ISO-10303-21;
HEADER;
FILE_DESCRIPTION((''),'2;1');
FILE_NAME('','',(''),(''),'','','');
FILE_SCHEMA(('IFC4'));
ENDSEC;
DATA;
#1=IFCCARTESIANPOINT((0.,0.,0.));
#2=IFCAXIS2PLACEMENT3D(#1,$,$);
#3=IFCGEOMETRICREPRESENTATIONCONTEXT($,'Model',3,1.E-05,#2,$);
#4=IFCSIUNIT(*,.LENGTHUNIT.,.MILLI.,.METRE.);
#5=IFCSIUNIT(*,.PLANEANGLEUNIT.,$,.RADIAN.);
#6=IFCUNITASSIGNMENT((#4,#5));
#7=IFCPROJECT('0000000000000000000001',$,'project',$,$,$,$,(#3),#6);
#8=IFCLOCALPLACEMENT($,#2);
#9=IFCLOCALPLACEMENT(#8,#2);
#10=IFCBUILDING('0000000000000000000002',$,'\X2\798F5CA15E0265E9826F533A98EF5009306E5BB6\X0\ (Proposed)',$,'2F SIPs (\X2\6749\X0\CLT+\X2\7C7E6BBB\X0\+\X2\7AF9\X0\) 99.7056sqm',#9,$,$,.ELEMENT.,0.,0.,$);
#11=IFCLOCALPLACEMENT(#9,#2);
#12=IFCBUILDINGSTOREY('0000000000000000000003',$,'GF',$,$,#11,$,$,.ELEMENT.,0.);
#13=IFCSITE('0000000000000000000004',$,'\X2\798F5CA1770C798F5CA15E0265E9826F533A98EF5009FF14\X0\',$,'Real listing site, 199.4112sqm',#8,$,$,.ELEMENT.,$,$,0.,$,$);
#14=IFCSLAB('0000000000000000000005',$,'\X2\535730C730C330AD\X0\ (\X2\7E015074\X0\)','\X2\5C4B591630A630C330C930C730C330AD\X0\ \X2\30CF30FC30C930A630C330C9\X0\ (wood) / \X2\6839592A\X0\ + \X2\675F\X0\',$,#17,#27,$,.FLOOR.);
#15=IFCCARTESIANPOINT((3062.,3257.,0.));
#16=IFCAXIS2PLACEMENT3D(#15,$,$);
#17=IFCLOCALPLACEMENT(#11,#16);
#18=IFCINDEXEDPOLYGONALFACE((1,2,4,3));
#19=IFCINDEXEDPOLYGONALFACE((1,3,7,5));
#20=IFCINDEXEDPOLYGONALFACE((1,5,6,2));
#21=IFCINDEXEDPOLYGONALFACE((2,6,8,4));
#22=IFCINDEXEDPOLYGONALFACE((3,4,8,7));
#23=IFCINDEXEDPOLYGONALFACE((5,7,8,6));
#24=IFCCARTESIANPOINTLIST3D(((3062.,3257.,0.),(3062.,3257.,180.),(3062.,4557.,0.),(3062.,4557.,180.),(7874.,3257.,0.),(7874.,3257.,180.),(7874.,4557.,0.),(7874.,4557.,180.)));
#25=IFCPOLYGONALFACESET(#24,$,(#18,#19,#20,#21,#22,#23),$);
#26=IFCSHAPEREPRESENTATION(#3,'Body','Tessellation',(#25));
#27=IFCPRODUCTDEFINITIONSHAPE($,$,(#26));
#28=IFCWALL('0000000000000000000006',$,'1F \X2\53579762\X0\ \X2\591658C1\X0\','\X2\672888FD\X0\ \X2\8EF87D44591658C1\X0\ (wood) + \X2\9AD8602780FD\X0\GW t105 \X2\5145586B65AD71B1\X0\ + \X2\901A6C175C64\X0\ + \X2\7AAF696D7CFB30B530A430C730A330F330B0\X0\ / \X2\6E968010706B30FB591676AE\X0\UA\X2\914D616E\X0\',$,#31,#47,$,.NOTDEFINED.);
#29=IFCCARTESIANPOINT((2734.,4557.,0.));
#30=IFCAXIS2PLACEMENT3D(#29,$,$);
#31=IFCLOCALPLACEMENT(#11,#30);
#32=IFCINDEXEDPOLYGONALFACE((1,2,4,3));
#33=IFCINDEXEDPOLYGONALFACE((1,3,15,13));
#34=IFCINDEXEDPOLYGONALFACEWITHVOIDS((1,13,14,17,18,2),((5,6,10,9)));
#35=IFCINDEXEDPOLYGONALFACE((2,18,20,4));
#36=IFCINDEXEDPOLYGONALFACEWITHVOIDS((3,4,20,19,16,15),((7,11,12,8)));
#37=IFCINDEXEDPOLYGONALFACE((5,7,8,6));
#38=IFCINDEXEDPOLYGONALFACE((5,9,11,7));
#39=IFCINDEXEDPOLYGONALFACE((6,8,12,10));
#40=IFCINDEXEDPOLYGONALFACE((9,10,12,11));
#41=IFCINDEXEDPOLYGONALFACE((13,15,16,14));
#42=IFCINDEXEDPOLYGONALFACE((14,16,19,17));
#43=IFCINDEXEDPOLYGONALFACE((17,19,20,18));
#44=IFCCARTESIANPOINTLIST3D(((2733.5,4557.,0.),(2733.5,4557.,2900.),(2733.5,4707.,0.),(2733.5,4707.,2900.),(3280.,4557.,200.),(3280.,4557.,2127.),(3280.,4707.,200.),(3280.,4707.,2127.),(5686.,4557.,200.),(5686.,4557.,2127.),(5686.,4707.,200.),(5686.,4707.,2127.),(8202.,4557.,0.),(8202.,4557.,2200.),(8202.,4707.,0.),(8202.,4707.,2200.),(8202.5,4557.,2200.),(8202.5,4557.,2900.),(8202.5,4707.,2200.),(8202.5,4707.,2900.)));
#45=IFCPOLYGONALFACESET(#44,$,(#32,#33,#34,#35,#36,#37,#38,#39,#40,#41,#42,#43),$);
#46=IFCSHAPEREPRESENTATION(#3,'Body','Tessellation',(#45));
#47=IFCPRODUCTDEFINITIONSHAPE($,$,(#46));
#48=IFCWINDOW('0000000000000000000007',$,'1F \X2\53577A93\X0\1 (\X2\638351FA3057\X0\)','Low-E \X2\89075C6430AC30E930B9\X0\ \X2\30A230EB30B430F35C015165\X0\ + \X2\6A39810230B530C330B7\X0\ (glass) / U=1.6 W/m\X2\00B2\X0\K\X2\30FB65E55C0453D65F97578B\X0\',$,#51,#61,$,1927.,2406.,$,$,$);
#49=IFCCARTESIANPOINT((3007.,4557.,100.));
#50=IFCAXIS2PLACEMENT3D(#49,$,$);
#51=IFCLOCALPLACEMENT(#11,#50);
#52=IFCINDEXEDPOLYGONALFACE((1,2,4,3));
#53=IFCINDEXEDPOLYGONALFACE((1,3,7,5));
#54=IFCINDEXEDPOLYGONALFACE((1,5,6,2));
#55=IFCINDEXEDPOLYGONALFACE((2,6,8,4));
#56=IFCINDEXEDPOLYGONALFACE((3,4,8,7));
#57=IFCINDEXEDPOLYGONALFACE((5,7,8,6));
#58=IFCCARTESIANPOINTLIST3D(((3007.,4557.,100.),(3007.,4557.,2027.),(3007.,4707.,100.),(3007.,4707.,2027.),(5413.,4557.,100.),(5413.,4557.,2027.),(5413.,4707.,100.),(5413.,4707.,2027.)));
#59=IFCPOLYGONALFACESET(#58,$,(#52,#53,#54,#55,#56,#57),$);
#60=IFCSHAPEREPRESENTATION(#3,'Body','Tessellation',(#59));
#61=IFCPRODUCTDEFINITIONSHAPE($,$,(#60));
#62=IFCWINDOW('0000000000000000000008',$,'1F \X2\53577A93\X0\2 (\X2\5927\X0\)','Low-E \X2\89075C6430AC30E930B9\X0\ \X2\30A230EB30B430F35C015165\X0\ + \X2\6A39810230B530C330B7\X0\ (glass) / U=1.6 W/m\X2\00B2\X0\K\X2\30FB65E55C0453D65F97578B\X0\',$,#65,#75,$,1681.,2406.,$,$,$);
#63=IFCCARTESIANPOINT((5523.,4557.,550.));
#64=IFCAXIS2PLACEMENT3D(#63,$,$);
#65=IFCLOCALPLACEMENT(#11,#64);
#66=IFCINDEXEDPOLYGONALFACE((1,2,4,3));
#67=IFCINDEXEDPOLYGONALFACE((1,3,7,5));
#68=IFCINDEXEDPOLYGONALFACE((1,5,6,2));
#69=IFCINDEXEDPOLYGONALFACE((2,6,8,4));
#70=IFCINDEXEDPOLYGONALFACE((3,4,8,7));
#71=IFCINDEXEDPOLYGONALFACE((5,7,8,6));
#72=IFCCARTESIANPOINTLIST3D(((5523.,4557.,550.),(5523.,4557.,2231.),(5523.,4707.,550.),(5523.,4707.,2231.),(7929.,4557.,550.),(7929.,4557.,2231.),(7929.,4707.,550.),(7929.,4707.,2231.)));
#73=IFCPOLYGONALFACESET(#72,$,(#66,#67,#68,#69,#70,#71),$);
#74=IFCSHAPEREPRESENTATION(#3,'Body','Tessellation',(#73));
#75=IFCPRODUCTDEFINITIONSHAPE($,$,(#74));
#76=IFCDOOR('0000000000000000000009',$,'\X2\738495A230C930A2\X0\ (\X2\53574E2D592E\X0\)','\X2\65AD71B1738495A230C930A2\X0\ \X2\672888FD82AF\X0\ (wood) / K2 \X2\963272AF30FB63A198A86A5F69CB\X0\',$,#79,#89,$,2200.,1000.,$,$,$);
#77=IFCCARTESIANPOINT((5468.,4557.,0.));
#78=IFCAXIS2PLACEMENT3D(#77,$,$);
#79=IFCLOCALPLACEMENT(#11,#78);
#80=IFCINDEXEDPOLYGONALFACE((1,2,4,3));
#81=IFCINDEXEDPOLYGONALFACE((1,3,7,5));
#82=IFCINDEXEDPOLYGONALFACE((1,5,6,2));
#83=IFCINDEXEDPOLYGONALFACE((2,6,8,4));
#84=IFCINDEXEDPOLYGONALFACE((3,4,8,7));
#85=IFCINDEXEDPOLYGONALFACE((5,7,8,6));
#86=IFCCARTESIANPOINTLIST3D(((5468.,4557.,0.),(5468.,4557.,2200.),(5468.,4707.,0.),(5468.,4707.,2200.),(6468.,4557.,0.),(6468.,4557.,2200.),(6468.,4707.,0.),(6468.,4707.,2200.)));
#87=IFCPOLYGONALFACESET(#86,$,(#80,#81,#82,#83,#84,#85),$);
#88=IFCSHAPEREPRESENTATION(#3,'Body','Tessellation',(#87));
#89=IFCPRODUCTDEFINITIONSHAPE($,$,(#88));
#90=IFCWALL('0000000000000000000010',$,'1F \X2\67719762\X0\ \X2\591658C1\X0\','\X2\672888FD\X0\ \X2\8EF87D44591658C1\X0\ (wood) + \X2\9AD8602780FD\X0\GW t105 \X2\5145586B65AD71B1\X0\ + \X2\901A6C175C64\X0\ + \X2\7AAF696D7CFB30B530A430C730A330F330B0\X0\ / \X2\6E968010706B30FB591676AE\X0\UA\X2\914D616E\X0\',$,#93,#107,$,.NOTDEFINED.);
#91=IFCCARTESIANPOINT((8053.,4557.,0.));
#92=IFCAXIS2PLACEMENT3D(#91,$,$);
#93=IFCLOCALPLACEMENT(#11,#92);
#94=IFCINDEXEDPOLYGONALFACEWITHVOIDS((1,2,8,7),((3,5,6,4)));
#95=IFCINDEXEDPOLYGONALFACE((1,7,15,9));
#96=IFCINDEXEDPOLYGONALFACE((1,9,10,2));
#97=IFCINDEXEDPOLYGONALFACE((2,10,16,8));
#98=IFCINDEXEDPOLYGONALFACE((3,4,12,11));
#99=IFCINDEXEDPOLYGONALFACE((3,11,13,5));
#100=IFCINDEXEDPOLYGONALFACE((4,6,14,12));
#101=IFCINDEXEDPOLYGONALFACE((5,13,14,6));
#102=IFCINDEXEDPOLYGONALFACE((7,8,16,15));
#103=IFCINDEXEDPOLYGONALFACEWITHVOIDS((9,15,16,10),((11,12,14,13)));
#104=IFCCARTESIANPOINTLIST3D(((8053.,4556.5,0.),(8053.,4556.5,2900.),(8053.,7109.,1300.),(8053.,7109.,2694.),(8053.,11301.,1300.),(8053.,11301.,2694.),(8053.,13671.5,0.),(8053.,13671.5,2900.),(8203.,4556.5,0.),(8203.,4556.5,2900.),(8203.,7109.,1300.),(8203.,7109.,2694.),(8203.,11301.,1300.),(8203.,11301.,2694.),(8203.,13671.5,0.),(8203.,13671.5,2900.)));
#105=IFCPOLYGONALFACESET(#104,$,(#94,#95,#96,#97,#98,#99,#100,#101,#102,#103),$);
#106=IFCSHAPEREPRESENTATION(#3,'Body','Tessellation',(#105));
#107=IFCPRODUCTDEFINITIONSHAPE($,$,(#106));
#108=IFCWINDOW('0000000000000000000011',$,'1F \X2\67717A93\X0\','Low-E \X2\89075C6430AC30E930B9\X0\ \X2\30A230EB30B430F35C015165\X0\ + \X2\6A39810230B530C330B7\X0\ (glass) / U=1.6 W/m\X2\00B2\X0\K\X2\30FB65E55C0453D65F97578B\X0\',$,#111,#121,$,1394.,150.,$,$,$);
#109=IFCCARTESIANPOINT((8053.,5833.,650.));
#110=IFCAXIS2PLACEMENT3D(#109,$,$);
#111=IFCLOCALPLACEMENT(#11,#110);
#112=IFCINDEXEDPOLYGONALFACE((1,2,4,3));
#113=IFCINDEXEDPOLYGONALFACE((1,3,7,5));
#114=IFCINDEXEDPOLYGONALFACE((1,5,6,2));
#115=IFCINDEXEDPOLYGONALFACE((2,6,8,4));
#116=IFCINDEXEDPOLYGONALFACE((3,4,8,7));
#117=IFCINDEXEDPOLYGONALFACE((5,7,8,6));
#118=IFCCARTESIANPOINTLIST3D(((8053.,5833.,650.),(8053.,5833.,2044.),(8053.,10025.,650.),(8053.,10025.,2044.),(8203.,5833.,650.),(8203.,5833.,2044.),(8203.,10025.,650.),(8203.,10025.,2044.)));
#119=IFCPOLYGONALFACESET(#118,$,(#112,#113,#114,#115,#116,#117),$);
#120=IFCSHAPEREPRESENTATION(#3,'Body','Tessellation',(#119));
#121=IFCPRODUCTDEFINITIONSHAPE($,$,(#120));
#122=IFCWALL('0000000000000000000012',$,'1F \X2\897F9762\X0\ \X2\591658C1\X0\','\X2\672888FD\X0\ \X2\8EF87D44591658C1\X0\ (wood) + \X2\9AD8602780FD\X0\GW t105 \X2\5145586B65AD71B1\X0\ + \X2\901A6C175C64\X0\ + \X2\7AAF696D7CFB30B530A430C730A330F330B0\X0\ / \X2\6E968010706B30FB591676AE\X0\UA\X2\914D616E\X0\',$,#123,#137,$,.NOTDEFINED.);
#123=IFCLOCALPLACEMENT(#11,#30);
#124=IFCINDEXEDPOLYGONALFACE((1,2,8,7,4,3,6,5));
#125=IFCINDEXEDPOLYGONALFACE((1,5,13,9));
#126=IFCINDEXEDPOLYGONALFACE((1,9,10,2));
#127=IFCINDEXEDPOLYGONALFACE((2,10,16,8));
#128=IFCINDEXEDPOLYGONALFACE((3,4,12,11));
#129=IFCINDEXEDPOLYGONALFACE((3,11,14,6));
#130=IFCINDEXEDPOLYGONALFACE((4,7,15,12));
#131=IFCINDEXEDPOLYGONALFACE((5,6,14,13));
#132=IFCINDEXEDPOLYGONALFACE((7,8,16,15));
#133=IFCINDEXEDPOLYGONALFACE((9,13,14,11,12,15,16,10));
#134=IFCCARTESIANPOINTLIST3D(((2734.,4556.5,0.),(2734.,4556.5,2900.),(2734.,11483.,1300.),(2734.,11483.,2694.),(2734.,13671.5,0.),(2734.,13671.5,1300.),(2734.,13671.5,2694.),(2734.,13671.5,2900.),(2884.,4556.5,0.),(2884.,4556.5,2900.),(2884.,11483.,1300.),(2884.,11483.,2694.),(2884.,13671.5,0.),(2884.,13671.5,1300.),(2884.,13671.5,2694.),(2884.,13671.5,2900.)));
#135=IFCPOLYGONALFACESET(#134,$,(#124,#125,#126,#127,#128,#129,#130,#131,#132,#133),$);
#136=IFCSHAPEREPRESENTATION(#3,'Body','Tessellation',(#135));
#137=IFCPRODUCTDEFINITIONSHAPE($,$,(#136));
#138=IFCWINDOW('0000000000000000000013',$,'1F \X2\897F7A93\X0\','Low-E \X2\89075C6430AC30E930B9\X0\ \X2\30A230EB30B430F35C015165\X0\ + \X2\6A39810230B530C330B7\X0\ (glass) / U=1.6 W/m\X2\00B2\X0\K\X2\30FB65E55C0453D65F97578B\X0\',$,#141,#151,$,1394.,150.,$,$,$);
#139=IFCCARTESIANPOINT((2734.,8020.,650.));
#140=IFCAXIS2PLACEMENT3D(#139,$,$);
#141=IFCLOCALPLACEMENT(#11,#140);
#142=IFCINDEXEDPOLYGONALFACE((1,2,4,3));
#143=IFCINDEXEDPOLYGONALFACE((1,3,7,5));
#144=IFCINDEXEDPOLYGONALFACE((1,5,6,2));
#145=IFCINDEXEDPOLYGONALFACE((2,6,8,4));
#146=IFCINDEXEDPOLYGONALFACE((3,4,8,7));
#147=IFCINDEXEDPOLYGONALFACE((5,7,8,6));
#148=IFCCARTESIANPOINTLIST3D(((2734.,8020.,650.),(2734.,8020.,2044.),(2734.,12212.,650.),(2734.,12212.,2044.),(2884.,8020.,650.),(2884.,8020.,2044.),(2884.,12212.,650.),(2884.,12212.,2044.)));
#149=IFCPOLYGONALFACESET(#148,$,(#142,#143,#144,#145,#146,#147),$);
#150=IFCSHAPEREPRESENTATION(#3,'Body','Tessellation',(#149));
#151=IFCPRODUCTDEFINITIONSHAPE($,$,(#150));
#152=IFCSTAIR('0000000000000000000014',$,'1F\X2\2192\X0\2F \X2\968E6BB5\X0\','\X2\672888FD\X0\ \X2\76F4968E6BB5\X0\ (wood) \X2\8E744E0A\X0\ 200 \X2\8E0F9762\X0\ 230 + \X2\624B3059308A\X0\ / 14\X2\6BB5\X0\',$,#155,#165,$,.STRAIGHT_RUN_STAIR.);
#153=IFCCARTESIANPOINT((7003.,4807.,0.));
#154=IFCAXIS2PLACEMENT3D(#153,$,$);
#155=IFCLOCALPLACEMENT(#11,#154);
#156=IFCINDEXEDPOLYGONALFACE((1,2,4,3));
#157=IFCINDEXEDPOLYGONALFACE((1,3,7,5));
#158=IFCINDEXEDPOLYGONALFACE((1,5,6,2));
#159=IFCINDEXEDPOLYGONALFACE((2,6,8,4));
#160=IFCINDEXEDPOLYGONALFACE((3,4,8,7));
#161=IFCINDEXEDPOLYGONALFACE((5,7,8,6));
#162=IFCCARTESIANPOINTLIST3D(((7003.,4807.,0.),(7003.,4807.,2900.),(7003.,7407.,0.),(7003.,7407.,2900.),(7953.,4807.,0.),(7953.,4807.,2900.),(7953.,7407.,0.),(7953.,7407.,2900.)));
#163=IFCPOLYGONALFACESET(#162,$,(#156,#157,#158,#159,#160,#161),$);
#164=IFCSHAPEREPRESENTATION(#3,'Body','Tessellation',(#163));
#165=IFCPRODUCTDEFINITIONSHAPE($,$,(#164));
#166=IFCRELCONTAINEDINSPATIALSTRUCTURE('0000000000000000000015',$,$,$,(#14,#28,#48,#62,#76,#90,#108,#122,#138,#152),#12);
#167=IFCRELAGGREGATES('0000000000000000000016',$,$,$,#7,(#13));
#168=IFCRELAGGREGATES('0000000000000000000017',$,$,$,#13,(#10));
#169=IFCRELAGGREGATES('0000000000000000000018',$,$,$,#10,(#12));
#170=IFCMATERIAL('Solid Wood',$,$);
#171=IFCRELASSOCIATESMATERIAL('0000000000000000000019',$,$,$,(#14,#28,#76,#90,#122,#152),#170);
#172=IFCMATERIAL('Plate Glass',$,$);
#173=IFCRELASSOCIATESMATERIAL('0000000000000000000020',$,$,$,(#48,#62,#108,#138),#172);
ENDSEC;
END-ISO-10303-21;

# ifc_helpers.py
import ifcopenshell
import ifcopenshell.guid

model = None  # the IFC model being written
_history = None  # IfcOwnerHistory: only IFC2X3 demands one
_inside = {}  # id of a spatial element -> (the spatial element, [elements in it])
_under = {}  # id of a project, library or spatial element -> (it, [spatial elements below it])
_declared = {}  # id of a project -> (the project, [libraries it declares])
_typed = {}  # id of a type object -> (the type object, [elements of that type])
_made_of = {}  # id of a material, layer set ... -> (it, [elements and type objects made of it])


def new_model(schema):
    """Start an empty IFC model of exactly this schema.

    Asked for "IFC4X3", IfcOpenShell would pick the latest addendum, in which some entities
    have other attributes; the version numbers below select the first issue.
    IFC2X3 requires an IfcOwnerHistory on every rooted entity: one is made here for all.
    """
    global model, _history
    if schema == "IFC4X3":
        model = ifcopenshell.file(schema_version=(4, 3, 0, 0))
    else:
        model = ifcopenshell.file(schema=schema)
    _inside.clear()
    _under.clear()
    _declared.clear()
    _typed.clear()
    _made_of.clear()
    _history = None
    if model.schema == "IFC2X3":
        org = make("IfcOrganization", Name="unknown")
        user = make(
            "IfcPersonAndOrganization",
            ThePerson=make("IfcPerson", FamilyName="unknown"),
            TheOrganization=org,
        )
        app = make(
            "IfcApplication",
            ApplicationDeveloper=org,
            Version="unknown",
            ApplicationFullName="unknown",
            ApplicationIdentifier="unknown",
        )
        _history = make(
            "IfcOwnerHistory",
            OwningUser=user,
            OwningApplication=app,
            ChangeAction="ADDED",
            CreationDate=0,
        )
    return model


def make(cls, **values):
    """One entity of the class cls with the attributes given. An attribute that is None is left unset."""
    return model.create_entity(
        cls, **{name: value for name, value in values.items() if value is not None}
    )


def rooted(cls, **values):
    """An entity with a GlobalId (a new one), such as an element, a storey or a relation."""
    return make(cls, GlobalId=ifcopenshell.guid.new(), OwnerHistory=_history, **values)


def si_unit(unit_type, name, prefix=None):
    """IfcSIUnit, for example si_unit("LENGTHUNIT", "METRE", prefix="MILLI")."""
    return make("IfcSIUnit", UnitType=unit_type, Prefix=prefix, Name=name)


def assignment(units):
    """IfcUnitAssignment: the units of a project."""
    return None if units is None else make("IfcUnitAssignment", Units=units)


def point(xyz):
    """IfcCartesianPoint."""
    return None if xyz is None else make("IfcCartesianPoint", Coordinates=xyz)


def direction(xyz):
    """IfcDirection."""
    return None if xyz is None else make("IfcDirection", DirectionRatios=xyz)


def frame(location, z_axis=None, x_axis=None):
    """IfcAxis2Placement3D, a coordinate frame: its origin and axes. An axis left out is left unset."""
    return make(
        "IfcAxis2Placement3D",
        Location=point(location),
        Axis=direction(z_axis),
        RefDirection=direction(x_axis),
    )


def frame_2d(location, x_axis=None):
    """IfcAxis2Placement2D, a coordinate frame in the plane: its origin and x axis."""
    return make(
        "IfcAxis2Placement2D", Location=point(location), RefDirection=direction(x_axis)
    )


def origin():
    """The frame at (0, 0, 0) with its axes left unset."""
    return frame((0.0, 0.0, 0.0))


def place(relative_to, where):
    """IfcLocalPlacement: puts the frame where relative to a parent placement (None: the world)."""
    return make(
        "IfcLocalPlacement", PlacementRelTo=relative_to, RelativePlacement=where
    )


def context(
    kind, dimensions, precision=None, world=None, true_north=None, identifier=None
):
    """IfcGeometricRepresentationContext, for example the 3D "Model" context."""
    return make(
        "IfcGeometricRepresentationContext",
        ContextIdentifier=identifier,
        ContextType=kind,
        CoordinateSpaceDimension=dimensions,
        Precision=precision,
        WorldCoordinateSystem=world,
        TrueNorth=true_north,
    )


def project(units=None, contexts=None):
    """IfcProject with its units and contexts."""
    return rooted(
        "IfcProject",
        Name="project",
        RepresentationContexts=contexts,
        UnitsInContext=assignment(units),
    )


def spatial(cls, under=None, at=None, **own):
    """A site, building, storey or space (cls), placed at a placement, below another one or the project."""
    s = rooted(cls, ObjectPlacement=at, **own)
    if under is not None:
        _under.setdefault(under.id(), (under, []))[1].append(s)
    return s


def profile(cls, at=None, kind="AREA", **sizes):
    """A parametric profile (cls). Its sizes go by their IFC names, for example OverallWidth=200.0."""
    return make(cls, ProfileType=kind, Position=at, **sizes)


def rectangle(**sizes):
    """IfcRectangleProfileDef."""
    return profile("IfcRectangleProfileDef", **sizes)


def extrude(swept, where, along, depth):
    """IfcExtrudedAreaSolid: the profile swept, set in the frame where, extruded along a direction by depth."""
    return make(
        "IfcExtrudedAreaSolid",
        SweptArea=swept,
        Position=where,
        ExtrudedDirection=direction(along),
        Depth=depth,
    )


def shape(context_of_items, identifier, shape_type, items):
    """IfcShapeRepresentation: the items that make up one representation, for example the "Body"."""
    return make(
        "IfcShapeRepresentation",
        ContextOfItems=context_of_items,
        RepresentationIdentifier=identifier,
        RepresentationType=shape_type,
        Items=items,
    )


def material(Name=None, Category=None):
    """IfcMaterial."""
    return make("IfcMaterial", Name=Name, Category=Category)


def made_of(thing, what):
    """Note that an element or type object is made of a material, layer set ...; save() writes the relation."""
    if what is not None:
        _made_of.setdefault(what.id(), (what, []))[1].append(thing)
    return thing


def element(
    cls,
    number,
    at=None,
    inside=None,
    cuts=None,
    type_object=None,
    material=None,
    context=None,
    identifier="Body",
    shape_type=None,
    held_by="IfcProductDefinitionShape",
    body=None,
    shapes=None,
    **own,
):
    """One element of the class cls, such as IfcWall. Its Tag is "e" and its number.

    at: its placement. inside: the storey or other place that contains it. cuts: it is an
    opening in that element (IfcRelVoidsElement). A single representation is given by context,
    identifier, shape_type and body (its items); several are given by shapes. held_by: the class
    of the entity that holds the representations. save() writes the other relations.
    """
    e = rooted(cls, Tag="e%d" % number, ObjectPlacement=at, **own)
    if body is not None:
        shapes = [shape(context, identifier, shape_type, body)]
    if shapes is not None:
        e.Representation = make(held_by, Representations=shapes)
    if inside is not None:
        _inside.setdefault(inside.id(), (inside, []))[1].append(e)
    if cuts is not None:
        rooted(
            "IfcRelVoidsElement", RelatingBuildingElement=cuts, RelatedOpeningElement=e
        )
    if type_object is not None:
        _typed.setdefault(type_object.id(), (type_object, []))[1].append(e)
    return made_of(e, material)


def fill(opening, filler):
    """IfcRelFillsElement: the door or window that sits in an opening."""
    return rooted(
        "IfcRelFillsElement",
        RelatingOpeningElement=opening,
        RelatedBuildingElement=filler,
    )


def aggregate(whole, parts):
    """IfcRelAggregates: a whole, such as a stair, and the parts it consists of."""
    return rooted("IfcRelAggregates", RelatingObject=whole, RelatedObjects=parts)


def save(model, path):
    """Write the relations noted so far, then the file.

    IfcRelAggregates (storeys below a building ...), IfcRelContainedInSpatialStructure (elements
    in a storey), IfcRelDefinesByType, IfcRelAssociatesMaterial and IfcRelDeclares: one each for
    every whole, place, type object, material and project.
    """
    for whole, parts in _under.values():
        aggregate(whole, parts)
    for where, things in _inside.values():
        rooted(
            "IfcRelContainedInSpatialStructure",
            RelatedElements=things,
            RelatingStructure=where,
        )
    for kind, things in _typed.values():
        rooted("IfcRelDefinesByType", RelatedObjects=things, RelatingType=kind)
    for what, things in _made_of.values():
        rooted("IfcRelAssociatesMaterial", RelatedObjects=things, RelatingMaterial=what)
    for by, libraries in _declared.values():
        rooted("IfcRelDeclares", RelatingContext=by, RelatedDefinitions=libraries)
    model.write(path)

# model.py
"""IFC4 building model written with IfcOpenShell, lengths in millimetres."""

from ifc_helpers import new_model, si_unit, frame, frame_2d, origin, place, context, project, spatial, rectangle, extrude, material, element, fill, save


model = new_model("IFC4")

# Units and contexts
model_context = context("Model", 3, precision=1e-05, world=origin())
ifc_project = project(units=[si_unit("LENGTHUNIT", "METRE", prefix="MILLI"), si_unit("PLANEANGLEUNIT", "RADIAN")], contexts=[model_context])

# Site, building, storey
site_placement = place(None, origin())
site = spatial("IfcSite", under=ifc_project, at=site_placement, Name="福岡県福岡市早良区飯倉４", ObjectType="Real listing site, 199.4112sqm", CompositionType="ELEMENT", RefElevation=0.0)
building_placement = place(site_placement, origin())
building = spatial("IfcBuilding", under=site, at=building_placement, Name="福岡市早良区飯倉の家 (Proposed)", ObjectType="2F SIPs (杉CLT+籾殻+竹) 99.7056sqm", CompositionType="ELEMENT", ElevationOfRefHeight=0.0, ElevationOfTerrain=0.0)
storey_placement = place(building_placement, origin())
storey = spatial("IfcBuildingStorey", under=building, at=storey_placement, Name="GF", CompositionType="ELEMENT", Elevation=0.0)

# Slab
ifc_material_1 = material(Name="Solid Wood")
slab_1_placement = place(storey_placement, frame((3062.0, 3257.0, 0.0)))
element("IfcSlab", 1, at=slab_1_placement, inside=storey, material=ifc_material_1, Name="南デッキ (縁側)", Description="屋外ウッドデッキ ハードウッド (wood) / 根太 + 束", PredefinedType="FLOOR", context=model_context, shape_type="SweptSolid", body=[
    extrude(rectangle(XDim=4812.0, YDim=1300.0, at=frame_2d((2406.0, 650.0))), frame((3062.0, 3257.0, 0.0)), (0.0, 0.0, 1.0), 180.0),
])

# Wall, openings, windows, door
wall_1_placement = place(storey_placement, frame((2734.0, 4557.0, 0.0)))
wall_1 = element("IfcWall", 2, at=wall_1_placement, inside=storey, material=ifc_material_1, Name="1F 南面 外壁", Description="木製 軸組外壁 (wood) + 高性能GW t105 充填断熱 + 通気層 + 窯業系サイディング / 準耐火・外皮UA配慮", PredefinedType="NOTDEFINED", context=model_context, shape_type="SweptSolid", body=[
    extrude(rectangle(XDim=5469.0, YDim=150.0, at=frame_2d((2734.0, 75.0))), frame((2734.0, 4557.0, 0.0)), (0.0, 0.0, 1.0), 2900.0),
])
opening_1_placement = place(storey_placement, frame((3007.0, 4557.0, 100.0)))
opening_1 = element("IfcOpeningElement", 3, at=opening_1_placement, cuts=wall_1, PredefinedType="NOTDEFINED", context=model_context, shape_type="SweptSolid", body=[
    extrude(rectangle(XDim=2406.0, YDim=150.0, at=frame_2d((1203.0, 75.0))), frame((3007.0, 4557.0, 100.0)), (0.0, 0.0, 1.0), 1927.0),
])
opening_2_placement = place(storey_placement, frame((5523.0, 4557.0, 550.0)))
opening_2 = element("IfcOpeningElement", 4, at=opening_2_placement, cuts=wall_1, PredefinedType="NOTDEFINED", context=model_context, shape_type="SweptSolid", body=[
    extrude(rectangle(XDim=2406.0, YDim=150.0, at=frame_2d((1203.0, 75.0))), frame((5523.0, 4557.0, 550.0)), (0.0, 0.0, 1.0), 1681.0),
])
opening_3_placement = place(storey_placement, frame((5468.0, 4557.0, 0.0)))
opening_3 = element("IfcOpeningElement", 5, at=opening_3_placement, cuts=wall_1, PredefinedType="NOTDEFINED", context=model_context, shape_type="SweptSolid", body=[
    extrude(rectangle(XDim=1000.0, YDim=150.0, at=frame_2d((500.0, 75.0))), frame((5468.0, 4557.0, 0.0)), (0.0, 0.0, 1.0), 2200.0),
])
ifc_material_2 = material(Name="Plate Glass")
window_1_placement = place(storey_placement, frame((3007.0, 4557.0, 100.0)))
window_1 = element("IfcWindow", 6, at=window_1_placement, inside=storey, material=ifc_material_2, Name="1F 南窓1 (掃出し)", Description="Low-E 複層ガラス アルゴン封入 + 樹脂サッシ (glass) / U=1.6 W/m²K・日射取得型", OverallHeight=1927.0, OverallWidth=2406.0, context=model_context, shape_type="SweptSolid", body=[
    extrude(rectangle(XDim=2406.0, YDim=150.0, at=frame_2d((1203.0, 75.0))), frame((3007.0, 4557.0, 100.0)), (0.0, 0.0, 1.0), 1927.0),
])
fill(opening_1, window_1)
window_2_placement = place(storey_placement, frame((5523.0, 4557.0, 550.0)))
window_2 = element("IfcWindow", 7, at=window_2_placement, inside=storey, material=ifc_material_2, Name="1F 南窓2 (大)", Description="Low-E 複層ガラス アルゴン封入 + 樹脂サッシ (glass) / U=1.6 W/m²K・日射取得型", OverallHeight=1681.0, OverallWidth=2406.0, context=model_context, shape_type="SweptSolid", body=[
    extrude(rectangle(XDim=2406.0, YDim=150.0, at=frame_2d((1203.0, 75.0))), frame((5523.0, 4557.0, 550.0)), (0.0, 0.0, 1.0), 1681.0),
])
fill(opening_2, window_2)
door_placement = place(storey_placement, frame((5468.0, 4557.0, 0.0)))
door = element("IfcDoor", 8, at=door_placement, inside=storey, material=ifc_material_1, Name="玄関ドア (南中央)", Description="断熱玄関ドア 木製芯 (wood) / K2 防犯・採風機構", OverallHeight=2200.0, OverallWidth=1000.0, context=model_context, shape_type="SweptSolid", body=[
    extrude(rectangle(XDim=1000.0, YDim=150.0, at=frame_2d((500.0, 75.0))), frame((5468.0, 4557.0, 0.0)), (0.0, 0.0, 1.0), 2200.0),
])
fill(opening_3, door)

# Walls, openings, windows
wall_2_placement = place(storey_placement, frame((8053.0, 4557.0, 0.0)))
wall_2 = element("IfcWall", 9, at=wall_2_placement, inside=storey, material=ifc_material_1, Name="1F 東面 外壁", Description="木製 軸組外壁 (wood) + 高性能GW t105 充填断熱 + 通気層 + 窯業系サイディング / 準耐火・外皮UA配慮", PredefinedType="NOTDEFINED", context=model_context, shape_type="SweptSolid", body=[
    extrude(rectangle(XDim=150.0, YDim=9115.0, at=frame_2d((75.0, 4557.0))), frame((8053.0, 4557.0, 0.0)), (0.0, 0.0, 1.0), 2900.0),
])
opening_4_placement = place(storey_placement, frame((8053.0, 5833.0, 650.0)))
opening_4 = element("IfcOpeningElement", 10, at=opening_4_placement, cuts=wall_2, PredefinedType="NOTDEFINED", context=model_context, shape_type="SweptSolid", body=[
    extrude(rectangle(XDim=150.0, YDim=4192.0, at=frame_2d((75.0, 2096.0))), frame((8053.0, 5833.0, 650.0)), (0.0, 0.0, 1.0), 1394.0),
])
window_3_placement = place(storey_placement, frame((8053.0, 5833.0, 650.0)))
window_3 = element("IfcWindow", 11, at=window_3_placement, inside=storey, material=ifc_material_2, Name="1F 東窓", Description="Low-E 複層ガラス アルゴン封入 + 樹脂サッシ (glass) / U=1.6 W/m²K・日射取得型", OverallHeight=1394.0, OverallWidth=150.0, context=model_context, shape_type="SweptSolid", body=[
    extrude(rectangle(XDim=150.0, YDim=4192.0, at=frame_2d((75.0, 2096.0))), frame((8053.0, 5833.0, 650.0)), (0.0, 0.0, 1.0), 1394.0),
])
fill(opening_4, window_3)
wall_3_placement = place(storey_placement, frame((2734.0, 4557.0, 0.0)))
wall_3 = element("IfcWall", 12, at=wall_3_placement, inside=storey, material=ifc_material_1, Name="1F 西面 外壁", Description="木製 軸組外壁 (wood) + 高性能GW t105 充填断熱 + 通気層 + 窯業系サイディング / 準耐火・外皮UA配慮", PredefinedType="NOTDEFINED", context=model_context, shape_type="SweptSolid", body=[
    extrude(rectangle(XDim=150.0, YDim=9115.0, at=frame_2d((75.0, 4557.0))), frame((2734.0, 4557.0, 0.0)), (0.0, 0.0, 1.0), 2900.0),
])
opening_5_placement = place(storey_placement, frame((2734.0, 8020.0, 650.0)))
opening_5 = element("IfcOpeningElement", 13, at=opening_5_placement, cuts=wall_3, PredefinedType="NOTDEFINED", context=model_context, shape_type="SweptSolid", body=[
    extrude(rectangle(XDim=150.0, YDim=4192.0, at=frame_2d((75.0, 2096.0))), frame((2734.0, 8020.0, 650.0)), (0.0, 0.0, 1.0), 1394.0),
])
window_4_placement = place(storey_placement, frame((2734.0, 8020.0, 650.0)))
window_4 = element("IfcWindow", 14, at=window_4_placement, inside=storey, material=ifc_material_2, Name="1F 西窓", Description="Low-E 複層ガラス アルゴン封入 + 樹脂サッシ (glass) / U=1.6 W/m²K・日射取得型", OverallHeight=1394.0, OverallWidth=150.0, context=model_context, shape_type="SweptSolid", body=[
    extrude(rectangle(XDim=150.0, YDim=4192.0, at=frame_2d((75.0, 2096.0))), frame((2734.0, 8020.0, 650.0)), (0.0, 0.0, 1.0), 1394.0),
])
fill(opening_5, window_4)

# Stair
stair_placement = place(storey_placement, frame((7003.0, 4807.0, 0.0)))
element("IfcStair", 15, at=stair_placement, inside=storey, material=ifc_material_1, Name="1F→2F 階段", Description="木製 直階段 (wood) 蹴上 200 踏面 230 + 手すり / 14段", PredefinedType="STRAIGHT_RUN_STAIR", context=model_context, shape_type="SweptSolid", body=[
    extrude(rectangle(XDim=950.0, YDim=2600.0, at=frame_2d((475.0, 1300.0))), frame((7003.0, 4807.0, 0.0)), (0.0, 0.0, 1.0), 2900.0),
])

save(model, "model.ifc")
